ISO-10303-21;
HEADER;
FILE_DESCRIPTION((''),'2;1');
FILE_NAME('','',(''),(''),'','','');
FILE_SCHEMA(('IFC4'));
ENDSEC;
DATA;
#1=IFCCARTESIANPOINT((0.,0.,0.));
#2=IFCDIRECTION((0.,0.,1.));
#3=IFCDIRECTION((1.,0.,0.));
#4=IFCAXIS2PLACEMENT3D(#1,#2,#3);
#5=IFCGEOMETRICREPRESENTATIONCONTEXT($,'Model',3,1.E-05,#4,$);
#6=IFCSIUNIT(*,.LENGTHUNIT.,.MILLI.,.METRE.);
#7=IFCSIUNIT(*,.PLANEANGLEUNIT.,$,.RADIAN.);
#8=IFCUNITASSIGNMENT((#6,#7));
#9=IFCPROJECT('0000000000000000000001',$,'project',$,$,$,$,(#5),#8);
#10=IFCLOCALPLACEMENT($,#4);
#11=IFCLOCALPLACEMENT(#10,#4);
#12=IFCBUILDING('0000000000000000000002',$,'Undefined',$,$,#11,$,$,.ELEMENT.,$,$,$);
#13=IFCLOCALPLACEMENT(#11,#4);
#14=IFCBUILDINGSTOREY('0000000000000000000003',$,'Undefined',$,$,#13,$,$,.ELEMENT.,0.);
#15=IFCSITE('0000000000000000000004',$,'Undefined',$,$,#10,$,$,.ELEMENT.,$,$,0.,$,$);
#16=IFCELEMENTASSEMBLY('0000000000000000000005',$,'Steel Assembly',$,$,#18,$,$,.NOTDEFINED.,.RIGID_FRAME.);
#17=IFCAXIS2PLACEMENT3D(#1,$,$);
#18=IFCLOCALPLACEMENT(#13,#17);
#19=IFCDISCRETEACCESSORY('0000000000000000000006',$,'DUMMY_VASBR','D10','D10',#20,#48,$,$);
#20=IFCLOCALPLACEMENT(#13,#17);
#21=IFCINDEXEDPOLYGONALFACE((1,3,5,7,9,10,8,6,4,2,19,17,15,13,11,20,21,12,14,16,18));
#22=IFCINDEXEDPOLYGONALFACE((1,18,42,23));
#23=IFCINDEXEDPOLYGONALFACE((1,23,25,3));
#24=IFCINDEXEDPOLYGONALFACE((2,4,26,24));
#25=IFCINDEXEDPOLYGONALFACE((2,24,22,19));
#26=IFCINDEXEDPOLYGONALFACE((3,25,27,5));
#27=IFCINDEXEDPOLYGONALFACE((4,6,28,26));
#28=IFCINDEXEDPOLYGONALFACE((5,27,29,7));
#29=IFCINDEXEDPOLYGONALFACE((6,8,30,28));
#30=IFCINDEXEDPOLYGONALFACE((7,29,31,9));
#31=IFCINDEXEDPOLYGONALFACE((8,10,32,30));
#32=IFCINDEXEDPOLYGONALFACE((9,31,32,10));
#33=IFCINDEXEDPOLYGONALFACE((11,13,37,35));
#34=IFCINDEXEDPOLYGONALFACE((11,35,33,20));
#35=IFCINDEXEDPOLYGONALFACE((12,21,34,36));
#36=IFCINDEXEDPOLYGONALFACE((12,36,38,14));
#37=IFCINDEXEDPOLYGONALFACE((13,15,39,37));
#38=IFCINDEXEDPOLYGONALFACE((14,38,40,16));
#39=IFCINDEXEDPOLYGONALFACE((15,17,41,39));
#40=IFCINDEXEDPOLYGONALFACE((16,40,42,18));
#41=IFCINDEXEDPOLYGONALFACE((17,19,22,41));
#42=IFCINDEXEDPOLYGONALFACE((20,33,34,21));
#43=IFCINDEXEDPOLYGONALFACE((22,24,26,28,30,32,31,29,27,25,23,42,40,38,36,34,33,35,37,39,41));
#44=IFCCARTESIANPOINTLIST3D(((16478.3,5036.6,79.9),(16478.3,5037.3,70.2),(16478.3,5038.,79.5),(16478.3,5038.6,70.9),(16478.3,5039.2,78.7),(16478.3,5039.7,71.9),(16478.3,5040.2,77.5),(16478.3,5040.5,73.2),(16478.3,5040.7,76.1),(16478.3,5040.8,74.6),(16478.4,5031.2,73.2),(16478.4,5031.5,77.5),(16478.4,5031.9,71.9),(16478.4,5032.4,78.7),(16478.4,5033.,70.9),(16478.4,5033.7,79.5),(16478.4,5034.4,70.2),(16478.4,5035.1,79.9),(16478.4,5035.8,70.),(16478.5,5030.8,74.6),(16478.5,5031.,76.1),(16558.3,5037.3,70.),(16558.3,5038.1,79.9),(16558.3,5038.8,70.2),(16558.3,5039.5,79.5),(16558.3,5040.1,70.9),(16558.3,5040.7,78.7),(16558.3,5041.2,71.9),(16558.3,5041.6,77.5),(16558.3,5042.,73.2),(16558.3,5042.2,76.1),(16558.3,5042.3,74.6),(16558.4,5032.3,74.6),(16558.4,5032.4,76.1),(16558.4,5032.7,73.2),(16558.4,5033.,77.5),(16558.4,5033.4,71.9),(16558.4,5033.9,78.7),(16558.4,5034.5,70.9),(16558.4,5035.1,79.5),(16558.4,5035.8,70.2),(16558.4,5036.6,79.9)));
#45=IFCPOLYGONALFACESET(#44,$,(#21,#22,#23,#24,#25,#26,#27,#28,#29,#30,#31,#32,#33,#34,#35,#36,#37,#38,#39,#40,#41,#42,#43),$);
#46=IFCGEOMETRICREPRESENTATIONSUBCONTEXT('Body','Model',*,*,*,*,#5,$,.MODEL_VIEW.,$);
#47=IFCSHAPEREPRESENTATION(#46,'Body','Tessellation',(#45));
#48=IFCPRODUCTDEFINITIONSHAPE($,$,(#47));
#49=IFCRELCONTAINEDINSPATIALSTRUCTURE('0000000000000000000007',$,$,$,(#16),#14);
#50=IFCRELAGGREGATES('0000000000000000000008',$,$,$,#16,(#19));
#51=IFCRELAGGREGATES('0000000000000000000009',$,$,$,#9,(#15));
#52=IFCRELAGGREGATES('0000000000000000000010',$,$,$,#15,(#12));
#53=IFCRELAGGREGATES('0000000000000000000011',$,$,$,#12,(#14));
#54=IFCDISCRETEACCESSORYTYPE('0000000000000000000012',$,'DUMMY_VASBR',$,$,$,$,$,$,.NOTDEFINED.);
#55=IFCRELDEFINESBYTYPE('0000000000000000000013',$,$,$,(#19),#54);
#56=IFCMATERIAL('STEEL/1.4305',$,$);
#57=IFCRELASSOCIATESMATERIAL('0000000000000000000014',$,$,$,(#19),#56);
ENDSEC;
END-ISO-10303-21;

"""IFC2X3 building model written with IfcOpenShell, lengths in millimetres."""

from ifc_helpers import new_model, si_unit, frame, origin_with_axes, origin_2d_with_axis, place, context, subcontext, project, spatial, circle, extrude, material, type_object, element, aggregate, save


model = new_model("IFC2X3")

# Units and contexts
model_context = context("Model", 3, precision=1e-05, world=origin_with_axes())
body_context = subcontext(model_context, "Body", "Model", "MODEL_VIEW")
ifc_project = project(units=[si_unit("LENGTHUNIT", "METRE", prefix="MILLI"), si_unit("PLANEANGLEUNIT", "RADIAN")], contexts=[model_context])

# Site, building, storey
site_placement = place(None, origin_with_axes())
site = spatial("IfcSite", under=ifc_project, at=site_placement, Name="Undefined", CompositionType="ELEMENT", RefElevation=0.0)
building_placement = place(site_placement, origin_with_axes())
building = spatial("IfcBuilding", under=site, at=building_placement, Name="Undefined", CompositionType="ELEMENT")
storey_placement = place(building_placement, origin_with_axes())
storey = spatial("IfcBuildingStorey", under=building, at=storey_placement, Name="Undefined", CompositionType="ELEMENT", Elevation=0.0)

# Element assembly
ifc_material_1 = material(Name="STEEL/1.4305")
assembly_1_placement = place(storey_placement, origin_with_axes())
assembly_1 = element("IfcElementAssembly", 1, at=assembly_1_placement, inside=storey, Name="Steel Assembly", AssemblyPlace="NOTDEFINED", PredefinedType="RIGID_FRAME")

# Discrete accessory
discrete_accessory_type_1 = type_object("IfcDiscreteAccessoryType", Name="DUMMY_VASBR")
discrete_accessory_1_placement = place(assembly_1_placement, frame((16558.3, 5037.3, 75.0), z_axis=(-0.018576, 0.999827, 0.0), x_axis=(-0.999827, -0.018576, 0.0)))
discrete_accessory_1 = element("IfcDiscreteAccessory", 2, at=discrete_accessory_1_placement, type_object=discrete_accessory_type_1, material=ifc_material_1, Name="DUMMY_VASBR", Description="D10", ObjectType="D10", context=body_context, shape_type="SweptSolid", body=[
    extrude(circle(Radius=5.0, at=origin_2d_with_axis()), frame((80.0, 0.0, 0.0), z_axis=(-1.0, 0.0, 0.0), x_axis=(0.0, -1.0, 0.0)), (0.0, 0.0, 1.0), 80.0),
])
aggregate(assembly_1, [discrete_accessory_1])

save(model, "model.ifc")
